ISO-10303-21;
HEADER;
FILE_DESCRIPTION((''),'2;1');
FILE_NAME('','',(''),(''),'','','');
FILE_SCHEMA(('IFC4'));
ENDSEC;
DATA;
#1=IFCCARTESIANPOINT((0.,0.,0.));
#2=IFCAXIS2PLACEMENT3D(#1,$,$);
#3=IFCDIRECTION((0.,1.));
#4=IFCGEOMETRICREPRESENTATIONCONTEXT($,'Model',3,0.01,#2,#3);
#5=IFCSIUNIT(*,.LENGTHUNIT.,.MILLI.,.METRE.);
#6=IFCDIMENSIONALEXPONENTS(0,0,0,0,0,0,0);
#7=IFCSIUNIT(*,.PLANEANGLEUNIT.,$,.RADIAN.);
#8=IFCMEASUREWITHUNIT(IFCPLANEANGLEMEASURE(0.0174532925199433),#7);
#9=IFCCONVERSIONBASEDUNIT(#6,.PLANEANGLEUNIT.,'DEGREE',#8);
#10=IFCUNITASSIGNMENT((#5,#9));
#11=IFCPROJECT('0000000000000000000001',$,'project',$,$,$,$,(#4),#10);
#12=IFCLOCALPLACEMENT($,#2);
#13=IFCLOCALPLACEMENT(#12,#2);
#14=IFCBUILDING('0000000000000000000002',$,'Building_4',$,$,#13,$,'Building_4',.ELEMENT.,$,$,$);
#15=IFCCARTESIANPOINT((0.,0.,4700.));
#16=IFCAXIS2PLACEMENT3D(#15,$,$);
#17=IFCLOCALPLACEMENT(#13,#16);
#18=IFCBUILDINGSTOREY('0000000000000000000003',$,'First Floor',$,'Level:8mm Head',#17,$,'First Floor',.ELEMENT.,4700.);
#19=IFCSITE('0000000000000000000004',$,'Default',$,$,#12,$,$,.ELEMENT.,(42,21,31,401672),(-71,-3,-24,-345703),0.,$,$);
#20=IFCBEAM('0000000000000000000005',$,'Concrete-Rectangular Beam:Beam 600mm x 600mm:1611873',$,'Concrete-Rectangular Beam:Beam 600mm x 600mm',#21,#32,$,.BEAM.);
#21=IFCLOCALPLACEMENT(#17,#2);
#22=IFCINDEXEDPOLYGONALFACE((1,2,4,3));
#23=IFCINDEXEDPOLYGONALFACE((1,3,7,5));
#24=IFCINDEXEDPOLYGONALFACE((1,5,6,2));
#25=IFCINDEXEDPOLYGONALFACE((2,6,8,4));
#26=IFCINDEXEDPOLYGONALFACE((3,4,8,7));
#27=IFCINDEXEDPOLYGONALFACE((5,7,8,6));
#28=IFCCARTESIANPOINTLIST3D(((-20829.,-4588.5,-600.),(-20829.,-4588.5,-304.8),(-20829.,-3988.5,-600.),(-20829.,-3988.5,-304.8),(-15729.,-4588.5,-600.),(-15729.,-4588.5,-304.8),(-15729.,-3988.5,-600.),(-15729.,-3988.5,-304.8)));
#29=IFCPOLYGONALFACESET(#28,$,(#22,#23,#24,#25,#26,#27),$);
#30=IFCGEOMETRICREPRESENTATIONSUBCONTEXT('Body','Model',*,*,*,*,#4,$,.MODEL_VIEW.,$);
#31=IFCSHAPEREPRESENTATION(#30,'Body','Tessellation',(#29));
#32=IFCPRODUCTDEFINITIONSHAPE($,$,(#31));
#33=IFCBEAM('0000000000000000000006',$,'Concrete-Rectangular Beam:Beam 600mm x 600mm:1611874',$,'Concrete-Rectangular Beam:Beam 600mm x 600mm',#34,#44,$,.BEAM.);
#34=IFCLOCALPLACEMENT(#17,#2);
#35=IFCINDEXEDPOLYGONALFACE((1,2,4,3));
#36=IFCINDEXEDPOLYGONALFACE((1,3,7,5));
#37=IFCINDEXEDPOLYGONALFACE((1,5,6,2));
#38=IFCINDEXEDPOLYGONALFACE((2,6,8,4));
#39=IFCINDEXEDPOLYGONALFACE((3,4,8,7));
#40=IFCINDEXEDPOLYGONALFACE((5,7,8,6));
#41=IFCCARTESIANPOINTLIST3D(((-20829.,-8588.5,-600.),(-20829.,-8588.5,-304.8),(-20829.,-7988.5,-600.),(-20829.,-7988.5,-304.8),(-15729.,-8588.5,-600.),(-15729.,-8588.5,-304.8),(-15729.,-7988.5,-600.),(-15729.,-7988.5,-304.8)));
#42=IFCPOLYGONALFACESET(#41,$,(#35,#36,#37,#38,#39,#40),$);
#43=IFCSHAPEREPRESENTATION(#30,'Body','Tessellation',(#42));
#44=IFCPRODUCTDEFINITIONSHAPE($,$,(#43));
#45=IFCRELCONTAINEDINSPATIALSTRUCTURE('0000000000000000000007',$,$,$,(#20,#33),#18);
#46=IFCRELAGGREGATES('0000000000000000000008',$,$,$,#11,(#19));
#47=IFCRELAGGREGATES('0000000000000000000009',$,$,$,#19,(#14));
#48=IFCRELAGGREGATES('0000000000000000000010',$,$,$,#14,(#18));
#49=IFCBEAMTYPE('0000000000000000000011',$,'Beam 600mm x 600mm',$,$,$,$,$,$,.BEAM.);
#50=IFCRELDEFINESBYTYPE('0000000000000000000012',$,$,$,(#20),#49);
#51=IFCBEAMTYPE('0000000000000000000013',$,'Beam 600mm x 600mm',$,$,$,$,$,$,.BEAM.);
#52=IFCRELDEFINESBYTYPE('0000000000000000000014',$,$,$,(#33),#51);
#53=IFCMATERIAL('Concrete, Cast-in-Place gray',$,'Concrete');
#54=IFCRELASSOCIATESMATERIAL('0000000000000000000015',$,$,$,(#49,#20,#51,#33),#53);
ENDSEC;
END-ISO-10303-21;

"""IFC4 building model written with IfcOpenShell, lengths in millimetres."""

from ifc_helpers import new_model, entity, si_unit, converted_unit, direction, frame, origin, place, context, subcontext, project, spatial, indexed_curve, outline, extrude, source, transform, mapped, material, type_object, type_shapes, element, save


model = new_model("IFC4")

# Units and contexts
model_context = context("Model", 3, precision=0.01, world=origin(), true_north=direction((0.0, 1.0)))
body_context = subcontext(model_context, "Body", "Model", "MODEL_VIEW")
ifc_project = project(units=[si_unit("LENGTHUNIT", "METRE", prefix="MILLI"), converted_unit("PLANEANGLEUNIT", "DEGREE", entity("IfcPlaneAngleMeasure", 0.0174532925199433), si_unit("PLANEANGLEUNIT", "RADIAN"), dimensions=[0, 0, 0, 0, 0, 0, 0])], contexts=[model_context])

# Site, building, storey
site_placement = place(None, origin())
site = spatial("IfcSite", under=ifc_project, at=site_placement, Name="Default", CompositionType="ELEMENT", RefLatitude=(42, 21, 31, 401672), RefLongitude=(-71, -3, -24, -345703), RefElevation=0.0)
building_placement = place(site_placement, origin())
building = spatial("IfcBuilding", under=site, at=building_placement, Name="Building_4", LongName="Building_4", CompositionType="ELEMENT")
storey_placement = place(building_placement, frame((0.0, 0.0, 4700.0)))
storey = spatial("IfcBuildingStorey", under=building, at=storey_placement, Name="First Floor", ObjectType="Level:8mm Head", LongName="First Floor", CompositionType="ELEMENT", Elevation=4700.0)

# Beams
ifc_material = material(Name="Concrete, Cast-in-Place gray", Category="Concrete")
beam_type_1 = type_object("IfcBeamType", Name="Beam 600mm x 600mm", PredefinedType="BEAM", material=ifc_material)
shared_shape_1 = source(origin(), body_context, "Body", "SweptSolid", [
    extrude(outline(indexed_curve([(-147.6, -300.0), (147.6, -300.0), (147.6, 300.0), (-147.6, 300.0), (-147.6, -300.0)], self_intersect=False)), frame((-15729.0, -4288.5, 4247.6), z_axis=(-1.0, 0.0, 0.0), x_axis=(0.0, 0.0, -1.0)), (0.0, 0.0, 1.0), 5100.0),
])
type_shapes(beam_type_1, [shared_shape_1])
beam_1_placement = place(storey_placement, frame((0.0, 0.0, -4700.0)))
element("IfcBeam", 1, at=beam_1_placement, inside=storey, type_object=beam_type_1, material=ifc_material, Name="Concrete-Rectangular Beam:Beam 600mm x 600mm:1611873", ObjectType="Concrete-Rectangular Beam:Beam 600mm x 600mm", PredefinedType="BEAM", context=body_context, shape_type="MappedRepresentation", body=[
    mapped(shared_shape_1, transform((0.0, 0.0, 0.0), scale=1.0)),
])
beam_type_2 = type_object("IfcBeamType", Name="Beam 600mm x 600mm", PredefinedType="BEAM", material=ifc_material)
shared_shape_2 = source(origin(), body_context, "Body", "SweptSolid", [
    extrude(outline(indexed_curve([(-147.6, -300.0), (147.6, -300.0), (147.6, 300.0), (-147.6, 300.0), (-147.6, -300.0)], self_intersect=False)), frame((-20829.0, -8288.5, 4247.6), z_axis=(1.0, 0.0, 0.0), x_axis=(0.0, 0.0, -1.0)), (0.0, 0.0, 1.0), 5100.0),
])
type_shapes(beam_type_2, [shared_shape_2])
beam_2_placement = place(storey_placement, frame((0.0, 0.0, -4700.0)))
element("IfcBeam", 2, at=beam_2_placement, inside=storey, type_object=beam_type_2, material=ifc_material, Name="Concrete-Rectangular Beam:Beam 600mm x 600mm:1611874", ObjectType="Concrete-Rectangular Beam:Beam 600mm x 600mm", PredefinedType="BEAM", context=body_context, shape_type="MappedRepresentation", body=[
    mapped(shared_shape_2, transform((0.0, 0.0, 0.0), scale=1.0)),
])

save(model, "model.ifc")
